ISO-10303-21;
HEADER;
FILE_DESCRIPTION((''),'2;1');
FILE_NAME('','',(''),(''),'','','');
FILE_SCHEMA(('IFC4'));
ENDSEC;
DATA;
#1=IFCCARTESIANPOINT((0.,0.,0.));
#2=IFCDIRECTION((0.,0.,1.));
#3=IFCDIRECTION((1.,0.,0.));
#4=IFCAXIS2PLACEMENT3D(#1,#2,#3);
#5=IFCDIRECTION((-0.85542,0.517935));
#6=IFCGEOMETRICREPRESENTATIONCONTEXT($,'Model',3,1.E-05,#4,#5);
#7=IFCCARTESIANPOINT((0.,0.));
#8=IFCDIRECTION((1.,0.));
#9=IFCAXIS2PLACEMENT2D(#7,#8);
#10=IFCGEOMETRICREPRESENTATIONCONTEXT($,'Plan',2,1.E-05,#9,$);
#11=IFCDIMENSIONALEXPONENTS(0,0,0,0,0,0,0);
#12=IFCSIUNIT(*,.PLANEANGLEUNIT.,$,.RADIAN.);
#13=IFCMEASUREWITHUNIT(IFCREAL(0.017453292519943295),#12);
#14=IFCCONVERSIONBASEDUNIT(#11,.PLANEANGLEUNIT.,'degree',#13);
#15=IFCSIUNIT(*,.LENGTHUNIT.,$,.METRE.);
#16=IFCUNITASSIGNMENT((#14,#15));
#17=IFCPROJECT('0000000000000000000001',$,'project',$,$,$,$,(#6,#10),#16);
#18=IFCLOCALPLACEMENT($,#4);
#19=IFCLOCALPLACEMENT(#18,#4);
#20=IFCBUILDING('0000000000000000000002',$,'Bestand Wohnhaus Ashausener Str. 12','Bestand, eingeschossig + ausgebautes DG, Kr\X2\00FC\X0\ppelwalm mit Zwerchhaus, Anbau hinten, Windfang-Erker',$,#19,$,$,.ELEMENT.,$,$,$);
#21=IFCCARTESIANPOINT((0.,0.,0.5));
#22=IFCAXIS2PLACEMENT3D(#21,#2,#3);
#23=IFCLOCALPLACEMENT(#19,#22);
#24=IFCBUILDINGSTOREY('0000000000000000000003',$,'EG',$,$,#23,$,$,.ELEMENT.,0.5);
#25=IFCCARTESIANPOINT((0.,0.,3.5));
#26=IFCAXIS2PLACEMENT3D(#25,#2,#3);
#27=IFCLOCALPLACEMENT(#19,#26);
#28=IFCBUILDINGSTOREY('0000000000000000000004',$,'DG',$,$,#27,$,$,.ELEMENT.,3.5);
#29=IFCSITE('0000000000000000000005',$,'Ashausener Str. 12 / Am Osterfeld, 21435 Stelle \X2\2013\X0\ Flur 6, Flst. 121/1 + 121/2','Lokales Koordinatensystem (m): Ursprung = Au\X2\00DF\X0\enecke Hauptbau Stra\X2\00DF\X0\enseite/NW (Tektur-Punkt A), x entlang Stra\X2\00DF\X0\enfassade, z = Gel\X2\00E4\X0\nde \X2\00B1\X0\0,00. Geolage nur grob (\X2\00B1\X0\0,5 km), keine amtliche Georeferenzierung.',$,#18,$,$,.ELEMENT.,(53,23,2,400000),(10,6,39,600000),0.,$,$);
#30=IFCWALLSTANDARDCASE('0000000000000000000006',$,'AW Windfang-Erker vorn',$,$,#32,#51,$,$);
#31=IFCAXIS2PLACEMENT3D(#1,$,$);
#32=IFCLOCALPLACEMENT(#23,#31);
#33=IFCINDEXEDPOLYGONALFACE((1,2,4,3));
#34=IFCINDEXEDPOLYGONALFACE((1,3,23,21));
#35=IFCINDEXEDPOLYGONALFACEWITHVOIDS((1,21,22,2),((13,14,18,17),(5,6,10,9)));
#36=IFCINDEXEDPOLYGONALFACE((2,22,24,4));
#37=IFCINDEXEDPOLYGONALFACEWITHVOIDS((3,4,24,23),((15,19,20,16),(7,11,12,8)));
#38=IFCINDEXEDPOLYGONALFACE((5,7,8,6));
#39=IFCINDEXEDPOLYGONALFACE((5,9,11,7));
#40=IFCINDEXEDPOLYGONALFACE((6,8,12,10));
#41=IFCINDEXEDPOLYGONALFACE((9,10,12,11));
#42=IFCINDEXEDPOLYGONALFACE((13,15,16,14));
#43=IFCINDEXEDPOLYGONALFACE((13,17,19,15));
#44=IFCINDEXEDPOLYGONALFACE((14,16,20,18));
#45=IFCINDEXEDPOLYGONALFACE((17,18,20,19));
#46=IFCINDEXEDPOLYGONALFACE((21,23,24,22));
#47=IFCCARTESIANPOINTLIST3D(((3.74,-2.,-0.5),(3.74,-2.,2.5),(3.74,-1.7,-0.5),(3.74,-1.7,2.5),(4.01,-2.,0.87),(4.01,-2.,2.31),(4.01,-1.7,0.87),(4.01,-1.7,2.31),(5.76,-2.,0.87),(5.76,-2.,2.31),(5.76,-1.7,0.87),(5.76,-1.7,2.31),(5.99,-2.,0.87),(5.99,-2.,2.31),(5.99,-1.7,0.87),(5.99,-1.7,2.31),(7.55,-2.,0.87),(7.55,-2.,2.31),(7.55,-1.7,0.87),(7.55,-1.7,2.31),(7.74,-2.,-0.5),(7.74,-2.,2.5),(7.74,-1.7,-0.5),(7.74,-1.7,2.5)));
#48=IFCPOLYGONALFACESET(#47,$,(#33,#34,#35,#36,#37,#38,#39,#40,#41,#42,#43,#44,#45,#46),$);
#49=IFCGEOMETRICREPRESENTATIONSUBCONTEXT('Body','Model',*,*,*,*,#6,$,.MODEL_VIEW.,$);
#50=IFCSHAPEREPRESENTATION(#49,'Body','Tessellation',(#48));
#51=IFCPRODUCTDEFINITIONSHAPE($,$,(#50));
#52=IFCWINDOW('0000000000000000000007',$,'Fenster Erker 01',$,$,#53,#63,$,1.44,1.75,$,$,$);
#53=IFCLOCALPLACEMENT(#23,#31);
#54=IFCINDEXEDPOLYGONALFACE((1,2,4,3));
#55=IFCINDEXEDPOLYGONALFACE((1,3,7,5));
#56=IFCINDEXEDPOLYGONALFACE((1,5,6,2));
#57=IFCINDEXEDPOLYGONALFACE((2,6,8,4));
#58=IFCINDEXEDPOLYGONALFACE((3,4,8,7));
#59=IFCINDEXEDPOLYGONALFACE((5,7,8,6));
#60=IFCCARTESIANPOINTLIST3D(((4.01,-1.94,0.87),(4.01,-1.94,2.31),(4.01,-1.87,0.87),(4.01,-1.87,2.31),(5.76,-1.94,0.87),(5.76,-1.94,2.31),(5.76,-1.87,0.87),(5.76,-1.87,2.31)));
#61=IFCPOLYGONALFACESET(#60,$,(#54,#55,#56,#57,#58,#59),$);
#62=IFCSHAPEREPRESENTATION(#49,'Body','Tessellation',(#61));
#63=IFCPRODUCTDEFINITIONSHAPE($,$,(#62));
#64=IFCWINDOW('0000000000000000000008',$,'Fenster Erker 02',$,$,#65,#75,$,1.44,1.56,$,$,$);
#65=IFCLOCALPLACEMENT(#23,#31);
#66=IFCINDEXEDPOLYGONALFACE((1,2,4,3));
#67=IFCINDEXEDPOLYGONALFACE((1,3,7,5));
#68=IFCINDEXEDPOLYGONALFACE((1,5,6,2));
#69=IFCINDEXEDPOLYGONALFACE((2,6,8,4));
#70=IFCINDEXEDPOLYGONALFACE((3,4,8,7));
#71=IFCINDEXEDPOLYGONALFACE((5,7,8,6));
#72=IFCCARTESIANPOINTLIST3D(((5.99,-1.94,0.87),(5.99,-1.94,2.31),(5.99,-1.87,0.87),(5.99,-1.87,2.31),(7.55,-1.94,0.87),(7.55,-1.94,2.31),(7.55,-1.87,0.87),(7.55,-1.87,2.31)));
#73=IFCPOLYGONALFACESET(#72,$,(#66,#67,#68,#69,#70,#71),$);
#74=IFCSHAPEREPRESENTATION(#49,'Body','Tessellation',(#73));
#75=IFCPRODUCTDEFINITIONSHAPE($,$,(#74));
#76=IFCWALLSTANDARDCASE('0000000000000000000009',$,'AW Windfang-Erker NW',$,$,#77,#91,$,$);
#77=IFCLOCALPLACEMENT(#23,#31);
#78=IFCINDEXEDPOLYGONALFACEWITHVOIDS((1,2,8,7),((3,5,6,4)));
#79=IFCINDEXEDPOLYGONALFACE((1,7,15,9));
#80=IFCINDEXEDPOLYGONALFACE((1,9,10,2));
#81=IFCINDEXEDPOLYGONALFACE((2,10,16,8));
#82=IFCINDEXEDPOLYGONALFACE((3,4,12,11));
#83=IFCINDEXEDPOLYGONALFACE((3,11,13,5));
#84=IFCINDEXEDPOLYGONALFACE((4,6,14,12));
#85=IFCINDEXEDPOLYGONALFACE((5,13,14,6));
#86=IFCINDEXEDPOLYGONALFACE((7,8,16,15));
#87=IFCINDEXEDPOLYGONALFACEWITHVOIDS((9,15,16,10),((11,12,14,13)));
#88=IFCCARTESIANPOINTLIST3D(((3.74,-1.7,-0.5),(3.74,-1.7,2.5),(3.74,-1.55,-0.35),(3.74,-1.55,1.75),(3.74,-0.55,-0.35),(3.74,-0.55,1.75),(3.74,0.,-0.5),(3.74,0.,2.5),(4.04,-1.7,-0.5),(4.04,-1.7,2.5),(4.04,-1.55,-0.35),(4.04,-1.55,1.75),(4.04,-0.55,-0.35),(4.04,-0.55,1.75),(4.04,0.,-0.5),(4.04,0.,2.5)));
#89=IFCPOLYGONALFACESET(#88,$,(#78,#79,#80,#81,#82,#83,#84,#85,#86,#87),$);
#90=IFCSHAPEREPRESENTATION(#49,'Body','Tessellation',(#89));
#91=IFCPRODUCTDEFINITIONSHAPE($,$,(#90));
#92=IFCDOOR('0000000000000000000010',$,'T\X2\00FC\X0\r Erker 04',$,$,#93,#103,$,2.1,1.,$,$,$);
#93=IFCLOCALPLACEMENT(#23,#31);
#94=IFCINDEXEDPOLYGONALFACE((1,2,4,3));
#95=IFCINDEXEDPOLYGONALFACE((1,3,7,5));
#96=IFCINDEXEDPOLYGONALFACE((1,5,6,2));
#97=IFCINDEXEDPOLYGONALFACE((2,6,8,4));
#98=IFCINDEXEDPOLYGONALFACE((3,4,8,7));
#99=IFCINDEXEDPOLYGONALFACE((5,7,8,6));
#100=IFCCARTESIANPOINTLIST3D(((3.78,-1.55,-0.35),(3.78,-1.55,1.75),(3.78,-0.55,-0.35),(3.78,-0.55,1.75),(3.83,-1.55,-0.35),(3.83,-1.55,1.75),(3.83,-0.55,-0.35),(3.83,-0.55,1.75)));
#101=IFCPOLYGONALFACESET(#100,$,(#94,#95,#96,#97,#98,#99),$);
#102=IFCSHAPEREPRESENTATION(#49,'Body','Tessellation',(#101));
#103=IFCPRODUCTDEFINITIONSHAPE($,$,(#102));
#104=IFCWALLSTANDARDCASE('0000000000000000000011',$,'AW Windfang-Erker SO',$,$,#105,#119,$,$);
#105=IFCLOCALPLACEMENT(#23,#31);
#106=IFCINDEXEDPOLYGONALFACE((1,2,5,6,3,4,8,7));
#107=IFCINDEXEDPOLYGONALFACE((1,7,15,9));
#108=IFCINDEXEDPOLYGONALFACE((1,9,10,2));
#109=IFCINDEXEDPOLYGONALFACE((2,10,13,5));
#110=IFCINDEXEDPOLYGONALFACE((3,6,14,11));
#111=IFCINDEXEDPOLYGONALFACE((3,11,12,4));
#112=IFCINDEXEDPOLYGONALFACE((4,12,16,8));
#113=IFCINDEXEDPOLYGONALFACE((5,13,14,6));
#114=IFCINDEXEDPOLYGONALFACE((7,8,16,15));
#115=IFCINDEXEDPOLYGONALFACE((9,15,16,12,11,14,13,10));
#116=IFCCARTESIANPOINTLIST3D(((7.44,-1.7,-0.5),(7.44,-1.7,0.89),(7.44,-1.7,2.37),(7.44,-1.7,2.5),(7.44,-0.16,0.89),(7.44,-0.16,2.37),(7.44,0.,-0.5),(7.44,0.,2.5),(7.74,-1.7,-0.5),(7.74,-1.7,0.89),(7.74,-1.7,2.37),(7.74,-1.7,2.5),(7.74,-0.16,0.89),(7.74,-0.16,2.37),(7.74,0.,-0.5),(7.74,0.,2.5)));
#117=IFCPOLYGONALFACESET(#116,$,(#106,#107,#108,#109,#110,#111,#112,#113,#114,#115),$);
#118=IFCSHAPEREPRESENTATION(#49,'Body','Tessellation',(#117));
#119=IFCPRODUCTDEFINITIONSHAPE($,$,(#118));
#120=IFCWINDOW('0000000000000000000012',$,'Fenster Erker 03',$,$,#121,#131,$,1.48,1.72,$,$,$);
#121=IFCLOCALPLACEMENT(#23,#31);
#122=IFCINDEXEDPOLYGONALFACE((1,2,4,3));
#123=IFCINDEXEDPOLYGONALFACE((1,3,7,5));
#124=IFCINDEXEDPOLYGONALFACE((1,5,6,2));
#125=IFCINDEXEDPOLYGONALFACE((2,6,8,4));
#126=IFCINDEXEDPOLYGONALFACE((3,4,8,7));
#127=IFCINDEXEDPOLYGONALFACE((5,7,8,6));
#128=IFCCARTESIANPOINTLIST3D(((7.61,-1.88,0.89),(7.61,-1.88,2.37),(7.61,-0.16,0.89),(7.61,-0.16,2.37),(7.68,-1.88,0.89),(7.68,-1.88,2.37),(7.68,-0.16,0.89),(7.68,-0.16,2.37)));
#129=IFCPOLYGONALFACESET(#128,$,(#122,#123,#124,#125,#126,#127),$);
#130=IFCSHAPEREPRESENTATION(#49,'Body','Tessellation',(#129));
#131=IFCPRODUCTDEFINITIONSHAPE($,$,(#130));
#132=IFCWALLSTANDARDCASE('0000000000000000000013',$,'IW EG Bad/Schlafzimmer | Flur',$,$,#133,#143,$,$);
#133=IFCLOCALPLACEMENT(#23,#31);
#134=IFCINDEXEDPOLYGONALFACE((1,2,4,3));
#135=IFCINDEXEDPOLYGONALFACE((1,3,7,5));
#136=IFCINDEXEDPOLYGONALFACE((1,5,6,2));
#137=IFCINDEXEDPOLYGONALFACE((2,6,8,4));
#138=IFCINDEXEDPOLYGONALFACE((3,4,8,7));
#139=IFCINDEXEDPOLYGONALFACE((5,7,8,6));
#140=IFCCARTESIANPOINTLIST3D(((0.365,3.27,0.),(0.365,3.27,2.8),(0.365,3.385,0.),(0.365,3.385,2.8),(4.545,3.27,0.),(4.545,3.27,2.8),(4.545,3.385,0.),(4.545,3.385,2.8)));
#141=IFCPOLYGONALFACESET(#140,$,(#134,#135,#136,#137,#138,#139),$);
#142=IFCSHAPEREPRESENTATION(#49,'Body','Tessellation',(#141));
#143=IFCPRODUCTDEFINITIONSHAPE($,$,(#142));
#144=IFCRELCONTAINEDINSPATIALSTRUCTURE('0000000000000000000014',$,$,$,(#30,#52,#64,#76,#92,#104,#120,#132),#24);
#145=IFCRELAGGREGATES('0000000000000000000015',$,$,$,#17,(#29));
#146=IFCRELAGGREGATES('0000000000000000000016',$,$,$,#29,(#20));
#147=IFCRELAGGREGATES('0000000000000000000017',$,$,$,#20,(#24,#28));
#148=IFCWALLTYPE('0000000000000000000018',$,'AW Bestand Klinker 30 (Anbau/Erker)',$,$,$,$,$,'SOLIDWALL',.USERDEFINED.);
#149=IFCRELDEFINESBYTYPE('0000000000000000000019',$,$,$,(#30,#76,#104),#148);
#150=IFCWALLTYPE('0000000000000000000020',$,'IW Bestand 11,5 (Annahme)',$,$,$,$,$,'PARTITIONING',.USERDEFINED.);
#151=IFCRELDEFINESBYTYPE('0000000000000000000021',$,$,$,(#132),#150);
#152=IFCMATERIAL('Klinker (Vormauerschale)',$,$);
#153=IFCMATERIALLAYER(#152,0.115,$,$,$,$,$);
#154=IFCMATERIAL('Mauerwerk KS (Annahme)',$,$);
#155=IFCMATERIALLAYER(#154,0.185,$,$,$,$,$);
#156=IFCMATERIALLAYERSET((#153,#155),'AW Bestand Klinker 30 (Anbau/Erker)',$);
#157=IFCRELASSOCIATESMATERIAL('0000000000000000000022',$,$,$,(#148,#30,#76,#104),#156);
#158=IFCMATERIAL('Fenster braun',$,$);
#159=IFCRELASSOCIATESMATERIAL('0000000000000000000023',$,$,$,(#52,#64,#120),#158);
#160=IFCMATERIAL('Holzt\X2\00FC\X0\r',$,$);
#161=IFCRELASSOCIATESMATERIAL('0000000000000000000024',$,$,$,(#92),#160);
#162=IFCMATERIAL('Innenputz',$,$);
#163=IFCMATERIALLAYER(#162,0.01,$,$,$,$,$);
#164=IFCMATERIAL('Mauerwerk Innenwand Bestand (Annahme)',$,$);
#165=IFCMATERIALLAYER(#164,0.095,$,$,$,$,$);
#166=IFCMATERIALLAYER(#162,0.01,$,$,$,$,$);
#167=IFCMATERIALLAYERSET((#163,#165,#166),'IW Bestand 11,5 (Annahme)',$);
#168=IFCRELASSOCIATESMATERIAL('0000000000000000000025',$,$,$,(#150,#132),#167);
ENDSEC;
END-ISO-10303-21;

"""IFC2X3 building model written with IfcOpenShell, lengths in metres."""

from ifc_helpers import new_model, entity, si_unit, converted_unit, direction, frame, origin_with_axes, origin_2d_with_axis, place, context, subcontext, project, spatial, polyline, outline, extrude, material, layer, layer_set, layer_usage, type_object, element, fill, save


model = new_model("IFC2X3")

# Units and contexts
model_context = context("Model", 3, precision=1e-05, world=origin_with_axes(), true_north=direction((-0.85542, 0.517935)))
plan_context = context("Plan", 2, precision=1e-05, world=origin_2d_with_axis())
body_context = subcontext(model_context, "Body", "Model", "MODEL_VIEW")
ifc_project = project(units=[converted_unit("PLANEANGLEUNIT", "degree", entity("IfcReal", 0.017453292519943295), si_unit("PLANEANGLEUNIT", "RADIAN"), dimensions=[0, 0, 0, 0, 0, 0, 0]), si_unit("LENGTHUNIT", "METRE")], contexts=[model_context, plan_context])

# Site, building, storey
site_placement = place(None, origin_with_axes())
site = spatial("IfcSite", under=ifc_project, at=site_placement, Name="Ashausener Str. 12 / Am Osterfeld, 21435 Stelle – Flur 6, Flst. 121/1 + 121/2", Description="Lokales Koordinatensystem (m): Ursprung = Außenecke Hauptbau Straßenseite/NW (Tektur-Punkt A), x entlang Straßenfassade, z = Gelände ±0,00. Geolage nur grob (±0,5 km), keine amtliche Georeferenzierung.", CompositionType="ELEMENT", RefLatitude=(53, 23, 2, 400000), RefLongitude=(10, 6, 39, 600000), RefElevation=0.0)
building_placement = place(site_placement, origin_with_axes())
building = spatial("IfcBuilding", under=site, at=building_placement, Name="Bestand Wohnhaus Ashausener Str. 12", Description="Bestand, eingeschossig + ausgebautes DG, Krüppelwalm mit Zwerchhaus, Anbau hinten, Windfang-Erker", CompositionType="ELEMENT")
storey_1_placement = place(building_placement, frame((0.0, 0.0, 0.5), z_axis=(0.0, 0.0, 1.0), x_axis=(1.0, 0.0, 0.0)))
storey_1 = spatial("IfcBuildingStorey", under=building, at=storey_1_placement, Name="EG", CompositionType="ELEMENT", Elevation=0.5)

# Shared definitions
ifc_material_1 = material(Name="Klinker (Vormauerschale)")
ifc_material_2 = material(Name="Mauerwerk KS (Annahme)")

# Shared definitions
storey_2_placement = place(building_placement, frame((0.0, 0.0, 3.5), z_axis=(0.0, 0.0, 1.0), x_axis=(1.0, 0.0, 0.0)))
storey_2 = spatial("IfcBuildingStorey", under=building, at=storey_2_placement, Name="DG", CompositionType="ELEMENT", Elevation=3.5)

# Wall, openings, windows
ifc_layer_1 = layer(ifc_material_1, 0.115)
ifc_layer_2 = layer(ifc_material_2, 0.185)
ifc_layer_set_1 = layer_set([ifc_layer_1, ifc_layer_2], Name="AW Bestand Klinker 30 (Anbau/Erker)")
ifc_layer_usage_1 = layer_usage(ifc_layer_set_1, "AXIS2", "POSITIVE", 0.0)
wall_type_1 = type_object("IfcWallType", Name="AW Bestand Klinker 30 (Anbau/Erker)", ElementType="SOLIDWALL", PredefinedType="USERDEFINED", material=ifc_layer_set_1)
wall_1_placement = place(storey_1_placement, frame((3.74, -2.0, -0.5), z_axis=(0.0, 0.0, 1.0), x_axis=(1.0, 0.0, 0.0)))
wall_1 = element("IfcWallStandardCase", 1, at=wall_1_placement, inside=storey_1, type_object=wall_type_1, material=ifc_layer_usage_1, Name="AW Windfang-Erker vorn", context=body_context, shape_type="SweptSolid", body=[
    extrude(outline(polyline([(0.0, 0.0), (0.0, 0.3), (4.0, 0.3), (4.0, 0.0), (0.0, 0.0)])), origin_with_axes(), (0.0, 0.0, 1.0), 3.0),
])
opening_1_placement = place(wall_1_placement, frame((0.27, -0.1, 1.37), z_axis=(0.0, 0.0, 1.0), x_axis=(1.0, 0.0, 0.0)))
opening_1 = element("IfcOpeningElement", 2, at=opening_1_placement, cuts=wall_1, context=body_context, shape_type="SweptSolid", body=[
    extrude(outline(polyline([(0.0, 0.0), (0.0, 0.5), (1.75, 0.5), (1.75, 0.0), (0.0, 0.0)])), origin_with_axes(), (0.0, 0.0, 1.0), 1.44),
])
opening_2_placement = place(wall_1_placement, frame((2.25, -0.1, 1.37), z_axis=(0.0, 0.0, 1.0), x_axis=(1.0, 0.0, 0.0)))
opening_2 = element("IfcOpeningElement", 3, at=opening_2_placement, cuts=wall_1, context=body_context, shape_type="SweptSolid", body=[
    extrude(outline(polyline([(0.0, 0.0), (0.0, 0.5), (1.56, 0.5), (1.56, 0.0), (0.0, 0.0)])), origin_with_axes(), (0.0, 0.0, 1.0), 1.44),
])
ifc_material_3 = material(Name="Fenster braun")
window_1_placement = place(storey_1_placement, frame((4.01, -1.94, 0.87), z_axis=(0.0, 0.0, 1.0), x_axis=(1.0, 0.0, 0.0)))
window_1 = element("IfcWindow", 4, at=window_1_placement, inside=storey_1, material=ifc_material_3, Name="Fenster Erker 01", OverallHeight=1.44, OverallWidth=1.75, context=body_context, shape_type="SweptSolid", body=[
    extrude(outline(polyline([(0.0, 0.0), (0.0, 0.07), (1.75, 0.07), (1.75, 0.0), (0.0, 0.0)])), origin_with_axes(), (0.0, 0.0, 1.0), 1.44),
])
fill(opening_1, window_1)
window_2_placement = place(storey_1_placement, frame((5.99, -1.94, 0.87), z_axis=(0.0, 0.0, 1.0), x_axis=(1.0, 0.0, 0.0)))
window_2 = element("IfcWindow", 5, at=window_2_placement, inside=storey_1, material=ifc_material_3, Name="Fenster Erker 02", OverallHeight=1.44, OverallWidth=1.56, context=body_context, shape_type="SweptSolid", body=[
    extrude(outline(polyline([(0.0, 0.0), (0.0, 0.07), (1.56, 0.07), (1.56, 0.0), (0.0, 0.0)])), origin_with_axes(), (0.0, 0.0, 1.0), 1.44),
])
fill(opening_2, window_2)

# Wall, opening, door
ifc_layer_usage_2 = layer_usage(ifc_layer_set_1, "AXIS2", "POSITIVE", 0.0)
wall_2_placement = place(storey_1_placement, frame((3.74, 0.0, -0.5), z_axis=(0.0, 0.0, 1.0), x_axis=(0.0, -1.0, 0.0)))
wall_2 = element("IfcWallStandardCase", 6, at=wall_2_placement, inside=storey_1, type_object=wall_type_1, material=ifc_layer_usage_2, Name="AW Windfang-Erker NW", context=body_context, shape_type="SweptSolid", body=[
    extrude(outline(polyline([(0.0, 0.0), (0.0, 0.3), (1.7, 0.3), (1.7, 0.0), (0.0, 0.0)])), origin_with_axes(), (0.0, 0.0, 1.0), 3.0),
])
opening_3_placement = place(wall_2_placement, frame((0.55, -0.1, 0.15), z_axis=(0.0, 0.0, 1.0), x_axis=(1.0, 0.0, 0.0)))
opening_3 = element("IfcOpeningElement", 7, at=opening_3_placement, cuts=wall_2, context=body_context, shape_type="SweptSolid", body=[
    extrude(outline(polyline([(0.0, 0.0), (0.0, 0.5), (1.0, 0.5), (1.0, 0.0), (0.0, 0.0)])), origin_with_axes(), (0.0, 0.0, 1.0), 2.1),
])
ifc_material_4 = material(Name="Holztür")
door_placement = place(storey_1_placement, frame((3.78, -0.55, -0.35), z_axis=(0.0, 0.0, 1.0), x_axis=(0.0, -1.0, 0.0)))
door = element("IfcDoor", 8, at=door_placement, inside=storey_1, material=ifc_material_4, Name="Tür Erker 04", OverallHeight=2.1, OverallWidth=1.0, context=body_context, shape_type="SweptSolid", body=[
    extrude(outline(polyline([(0.0, 0.0), (0.0, 0.05), (1.0, 0.05), (1.0, 0.0), (0.0, 0.0)])), origin_with_axes(), (0.0, 0.0, 1.0), 2.1),
])
fill(opening_3, door)

# Wall, opening, window
ifc_layer_usage_3 = layer_usage(ifc_layer_set_1, "AXIS2", "POSITIVE", 0.0)
wall_3_placement = place(storey_1_placement, frame((7.74, -1.7, -0.5), z_axis=(0.0, 0.0, 1.0), x_axis=(0.0, 1.0, 0.0)))
wall_3 = element("IfcWallStandardCase", 9, at=wall_3_placement, inside=storey_1, type_object=wall_type_1, material=ifc_layer_usage_3, Name="AW Windfang-Erker SO", context=body_context, shape_type="SweptSolid", body=[
    extrude(outline(polyline([(0.0, 0.0), (0.0, 0.3), (1.7, 0.3), (1.7, 0.0), (0.0, 0.0)])), origin_with_axes(), (0.0, 0.0, 1.0), 3.0),
])
opening_4_placement = place(wall_3_placement, frame((-0.18, -0.1, 1.39), z_axis=(0.0, 0.0, 1.0), x_axis=(1.0, 0.0, 0.0)))
opening_4 = element("IfcOpeningElement", 10, at=opening_4_placement, cuts=wall_3, context=body_context, shape_type="SweptSolid", body=[
    extrude(outline(polyline([(0.0, 0.0), (0.0, 0.5), (1.72, 0.5), (1.72, 0.0), (0.0, 0.0)])), origin_with_axes(), (0.0, 0.0, 1.0), 1.48),
])
window_3_placement = place(storey_1_placement, frame((7.68, -1.88, 0.89), z_axis=(0.0, 0.0, 1.0), x_axis=(0.0, 1.0, 0.0)))
window_3 = element("IfcWindow", 11, at=window_3_placement, inside=storey_1, material=ifc_material_3, Name="Fenster Erker 03", OverallHeight=1.48, OverallWidth=1.72, context=body_context, shape_type="SweptSolid", body=[
    extrude(outline(polyline([(0.0, 0.0), (0.0, 0.07), (1.72, 0.07), (1.72, 0.0), (0.0, 0.0)])), origin_with_axes(), (0.0, 0.0, 1.0), 1.48),
])
fill(opening_4, window_3)

# Wall
ifc_material_5 = material(Name="Innenputz")
ifc_layer_3 = layer(ifc_material_5, 0.01)
ifc_material_6 = material(Name="Mauerwerk Innenwand Bestand (Annahme)")
ifc_layer_4 = layer(ifc_material_6, 0.095)
ifc_layer_5 = layer(ifc_material_5, 0.01)
ifc_layer_set_2 = layer_set([ifc_layer_3, ifc_layer_4, ifc_layer_5], Name="IW Bestand 11,5 (Annahme)")
ifc_layer_usage_4 = layer_usage(ifc_layer_set_2, "AXIS2", "POSITIVE", 0.0)
wall_type_2 = type_object("IfcWallType", Name="IW Bestand 11,5 (Annahme)", ElementType="PARTITIONING", PredefinedType="USERDEFINED", material=ifc_layer_set_2)
wall_4_placement = place(storey_1_placement, frame((0.365, 3.27, 0.0), z_axis=(0.0, 0.0, 1.0), x_axis=(1.0, 0.0, 0.0)))
element("IfcWallStandardCase", 12, at=wall_4_placement, inside=storey_1, type_object=wall_type_2, material=ifc_layer_usage_4, Name="IW EG Bad/Schlafzimmer | Flur", context=body_context, shape_type="SweptSolid", body=[
    extrude(outline(polyline([(0.0, 0.0), (0.0, 0.115), (4.18, 0.115), (4.18, 0.0), (0.0, 0.0)])), origin_with_axes(), (0.0, 0.0, 1.0), 2.8),
])

save(model, "model.ifc")
